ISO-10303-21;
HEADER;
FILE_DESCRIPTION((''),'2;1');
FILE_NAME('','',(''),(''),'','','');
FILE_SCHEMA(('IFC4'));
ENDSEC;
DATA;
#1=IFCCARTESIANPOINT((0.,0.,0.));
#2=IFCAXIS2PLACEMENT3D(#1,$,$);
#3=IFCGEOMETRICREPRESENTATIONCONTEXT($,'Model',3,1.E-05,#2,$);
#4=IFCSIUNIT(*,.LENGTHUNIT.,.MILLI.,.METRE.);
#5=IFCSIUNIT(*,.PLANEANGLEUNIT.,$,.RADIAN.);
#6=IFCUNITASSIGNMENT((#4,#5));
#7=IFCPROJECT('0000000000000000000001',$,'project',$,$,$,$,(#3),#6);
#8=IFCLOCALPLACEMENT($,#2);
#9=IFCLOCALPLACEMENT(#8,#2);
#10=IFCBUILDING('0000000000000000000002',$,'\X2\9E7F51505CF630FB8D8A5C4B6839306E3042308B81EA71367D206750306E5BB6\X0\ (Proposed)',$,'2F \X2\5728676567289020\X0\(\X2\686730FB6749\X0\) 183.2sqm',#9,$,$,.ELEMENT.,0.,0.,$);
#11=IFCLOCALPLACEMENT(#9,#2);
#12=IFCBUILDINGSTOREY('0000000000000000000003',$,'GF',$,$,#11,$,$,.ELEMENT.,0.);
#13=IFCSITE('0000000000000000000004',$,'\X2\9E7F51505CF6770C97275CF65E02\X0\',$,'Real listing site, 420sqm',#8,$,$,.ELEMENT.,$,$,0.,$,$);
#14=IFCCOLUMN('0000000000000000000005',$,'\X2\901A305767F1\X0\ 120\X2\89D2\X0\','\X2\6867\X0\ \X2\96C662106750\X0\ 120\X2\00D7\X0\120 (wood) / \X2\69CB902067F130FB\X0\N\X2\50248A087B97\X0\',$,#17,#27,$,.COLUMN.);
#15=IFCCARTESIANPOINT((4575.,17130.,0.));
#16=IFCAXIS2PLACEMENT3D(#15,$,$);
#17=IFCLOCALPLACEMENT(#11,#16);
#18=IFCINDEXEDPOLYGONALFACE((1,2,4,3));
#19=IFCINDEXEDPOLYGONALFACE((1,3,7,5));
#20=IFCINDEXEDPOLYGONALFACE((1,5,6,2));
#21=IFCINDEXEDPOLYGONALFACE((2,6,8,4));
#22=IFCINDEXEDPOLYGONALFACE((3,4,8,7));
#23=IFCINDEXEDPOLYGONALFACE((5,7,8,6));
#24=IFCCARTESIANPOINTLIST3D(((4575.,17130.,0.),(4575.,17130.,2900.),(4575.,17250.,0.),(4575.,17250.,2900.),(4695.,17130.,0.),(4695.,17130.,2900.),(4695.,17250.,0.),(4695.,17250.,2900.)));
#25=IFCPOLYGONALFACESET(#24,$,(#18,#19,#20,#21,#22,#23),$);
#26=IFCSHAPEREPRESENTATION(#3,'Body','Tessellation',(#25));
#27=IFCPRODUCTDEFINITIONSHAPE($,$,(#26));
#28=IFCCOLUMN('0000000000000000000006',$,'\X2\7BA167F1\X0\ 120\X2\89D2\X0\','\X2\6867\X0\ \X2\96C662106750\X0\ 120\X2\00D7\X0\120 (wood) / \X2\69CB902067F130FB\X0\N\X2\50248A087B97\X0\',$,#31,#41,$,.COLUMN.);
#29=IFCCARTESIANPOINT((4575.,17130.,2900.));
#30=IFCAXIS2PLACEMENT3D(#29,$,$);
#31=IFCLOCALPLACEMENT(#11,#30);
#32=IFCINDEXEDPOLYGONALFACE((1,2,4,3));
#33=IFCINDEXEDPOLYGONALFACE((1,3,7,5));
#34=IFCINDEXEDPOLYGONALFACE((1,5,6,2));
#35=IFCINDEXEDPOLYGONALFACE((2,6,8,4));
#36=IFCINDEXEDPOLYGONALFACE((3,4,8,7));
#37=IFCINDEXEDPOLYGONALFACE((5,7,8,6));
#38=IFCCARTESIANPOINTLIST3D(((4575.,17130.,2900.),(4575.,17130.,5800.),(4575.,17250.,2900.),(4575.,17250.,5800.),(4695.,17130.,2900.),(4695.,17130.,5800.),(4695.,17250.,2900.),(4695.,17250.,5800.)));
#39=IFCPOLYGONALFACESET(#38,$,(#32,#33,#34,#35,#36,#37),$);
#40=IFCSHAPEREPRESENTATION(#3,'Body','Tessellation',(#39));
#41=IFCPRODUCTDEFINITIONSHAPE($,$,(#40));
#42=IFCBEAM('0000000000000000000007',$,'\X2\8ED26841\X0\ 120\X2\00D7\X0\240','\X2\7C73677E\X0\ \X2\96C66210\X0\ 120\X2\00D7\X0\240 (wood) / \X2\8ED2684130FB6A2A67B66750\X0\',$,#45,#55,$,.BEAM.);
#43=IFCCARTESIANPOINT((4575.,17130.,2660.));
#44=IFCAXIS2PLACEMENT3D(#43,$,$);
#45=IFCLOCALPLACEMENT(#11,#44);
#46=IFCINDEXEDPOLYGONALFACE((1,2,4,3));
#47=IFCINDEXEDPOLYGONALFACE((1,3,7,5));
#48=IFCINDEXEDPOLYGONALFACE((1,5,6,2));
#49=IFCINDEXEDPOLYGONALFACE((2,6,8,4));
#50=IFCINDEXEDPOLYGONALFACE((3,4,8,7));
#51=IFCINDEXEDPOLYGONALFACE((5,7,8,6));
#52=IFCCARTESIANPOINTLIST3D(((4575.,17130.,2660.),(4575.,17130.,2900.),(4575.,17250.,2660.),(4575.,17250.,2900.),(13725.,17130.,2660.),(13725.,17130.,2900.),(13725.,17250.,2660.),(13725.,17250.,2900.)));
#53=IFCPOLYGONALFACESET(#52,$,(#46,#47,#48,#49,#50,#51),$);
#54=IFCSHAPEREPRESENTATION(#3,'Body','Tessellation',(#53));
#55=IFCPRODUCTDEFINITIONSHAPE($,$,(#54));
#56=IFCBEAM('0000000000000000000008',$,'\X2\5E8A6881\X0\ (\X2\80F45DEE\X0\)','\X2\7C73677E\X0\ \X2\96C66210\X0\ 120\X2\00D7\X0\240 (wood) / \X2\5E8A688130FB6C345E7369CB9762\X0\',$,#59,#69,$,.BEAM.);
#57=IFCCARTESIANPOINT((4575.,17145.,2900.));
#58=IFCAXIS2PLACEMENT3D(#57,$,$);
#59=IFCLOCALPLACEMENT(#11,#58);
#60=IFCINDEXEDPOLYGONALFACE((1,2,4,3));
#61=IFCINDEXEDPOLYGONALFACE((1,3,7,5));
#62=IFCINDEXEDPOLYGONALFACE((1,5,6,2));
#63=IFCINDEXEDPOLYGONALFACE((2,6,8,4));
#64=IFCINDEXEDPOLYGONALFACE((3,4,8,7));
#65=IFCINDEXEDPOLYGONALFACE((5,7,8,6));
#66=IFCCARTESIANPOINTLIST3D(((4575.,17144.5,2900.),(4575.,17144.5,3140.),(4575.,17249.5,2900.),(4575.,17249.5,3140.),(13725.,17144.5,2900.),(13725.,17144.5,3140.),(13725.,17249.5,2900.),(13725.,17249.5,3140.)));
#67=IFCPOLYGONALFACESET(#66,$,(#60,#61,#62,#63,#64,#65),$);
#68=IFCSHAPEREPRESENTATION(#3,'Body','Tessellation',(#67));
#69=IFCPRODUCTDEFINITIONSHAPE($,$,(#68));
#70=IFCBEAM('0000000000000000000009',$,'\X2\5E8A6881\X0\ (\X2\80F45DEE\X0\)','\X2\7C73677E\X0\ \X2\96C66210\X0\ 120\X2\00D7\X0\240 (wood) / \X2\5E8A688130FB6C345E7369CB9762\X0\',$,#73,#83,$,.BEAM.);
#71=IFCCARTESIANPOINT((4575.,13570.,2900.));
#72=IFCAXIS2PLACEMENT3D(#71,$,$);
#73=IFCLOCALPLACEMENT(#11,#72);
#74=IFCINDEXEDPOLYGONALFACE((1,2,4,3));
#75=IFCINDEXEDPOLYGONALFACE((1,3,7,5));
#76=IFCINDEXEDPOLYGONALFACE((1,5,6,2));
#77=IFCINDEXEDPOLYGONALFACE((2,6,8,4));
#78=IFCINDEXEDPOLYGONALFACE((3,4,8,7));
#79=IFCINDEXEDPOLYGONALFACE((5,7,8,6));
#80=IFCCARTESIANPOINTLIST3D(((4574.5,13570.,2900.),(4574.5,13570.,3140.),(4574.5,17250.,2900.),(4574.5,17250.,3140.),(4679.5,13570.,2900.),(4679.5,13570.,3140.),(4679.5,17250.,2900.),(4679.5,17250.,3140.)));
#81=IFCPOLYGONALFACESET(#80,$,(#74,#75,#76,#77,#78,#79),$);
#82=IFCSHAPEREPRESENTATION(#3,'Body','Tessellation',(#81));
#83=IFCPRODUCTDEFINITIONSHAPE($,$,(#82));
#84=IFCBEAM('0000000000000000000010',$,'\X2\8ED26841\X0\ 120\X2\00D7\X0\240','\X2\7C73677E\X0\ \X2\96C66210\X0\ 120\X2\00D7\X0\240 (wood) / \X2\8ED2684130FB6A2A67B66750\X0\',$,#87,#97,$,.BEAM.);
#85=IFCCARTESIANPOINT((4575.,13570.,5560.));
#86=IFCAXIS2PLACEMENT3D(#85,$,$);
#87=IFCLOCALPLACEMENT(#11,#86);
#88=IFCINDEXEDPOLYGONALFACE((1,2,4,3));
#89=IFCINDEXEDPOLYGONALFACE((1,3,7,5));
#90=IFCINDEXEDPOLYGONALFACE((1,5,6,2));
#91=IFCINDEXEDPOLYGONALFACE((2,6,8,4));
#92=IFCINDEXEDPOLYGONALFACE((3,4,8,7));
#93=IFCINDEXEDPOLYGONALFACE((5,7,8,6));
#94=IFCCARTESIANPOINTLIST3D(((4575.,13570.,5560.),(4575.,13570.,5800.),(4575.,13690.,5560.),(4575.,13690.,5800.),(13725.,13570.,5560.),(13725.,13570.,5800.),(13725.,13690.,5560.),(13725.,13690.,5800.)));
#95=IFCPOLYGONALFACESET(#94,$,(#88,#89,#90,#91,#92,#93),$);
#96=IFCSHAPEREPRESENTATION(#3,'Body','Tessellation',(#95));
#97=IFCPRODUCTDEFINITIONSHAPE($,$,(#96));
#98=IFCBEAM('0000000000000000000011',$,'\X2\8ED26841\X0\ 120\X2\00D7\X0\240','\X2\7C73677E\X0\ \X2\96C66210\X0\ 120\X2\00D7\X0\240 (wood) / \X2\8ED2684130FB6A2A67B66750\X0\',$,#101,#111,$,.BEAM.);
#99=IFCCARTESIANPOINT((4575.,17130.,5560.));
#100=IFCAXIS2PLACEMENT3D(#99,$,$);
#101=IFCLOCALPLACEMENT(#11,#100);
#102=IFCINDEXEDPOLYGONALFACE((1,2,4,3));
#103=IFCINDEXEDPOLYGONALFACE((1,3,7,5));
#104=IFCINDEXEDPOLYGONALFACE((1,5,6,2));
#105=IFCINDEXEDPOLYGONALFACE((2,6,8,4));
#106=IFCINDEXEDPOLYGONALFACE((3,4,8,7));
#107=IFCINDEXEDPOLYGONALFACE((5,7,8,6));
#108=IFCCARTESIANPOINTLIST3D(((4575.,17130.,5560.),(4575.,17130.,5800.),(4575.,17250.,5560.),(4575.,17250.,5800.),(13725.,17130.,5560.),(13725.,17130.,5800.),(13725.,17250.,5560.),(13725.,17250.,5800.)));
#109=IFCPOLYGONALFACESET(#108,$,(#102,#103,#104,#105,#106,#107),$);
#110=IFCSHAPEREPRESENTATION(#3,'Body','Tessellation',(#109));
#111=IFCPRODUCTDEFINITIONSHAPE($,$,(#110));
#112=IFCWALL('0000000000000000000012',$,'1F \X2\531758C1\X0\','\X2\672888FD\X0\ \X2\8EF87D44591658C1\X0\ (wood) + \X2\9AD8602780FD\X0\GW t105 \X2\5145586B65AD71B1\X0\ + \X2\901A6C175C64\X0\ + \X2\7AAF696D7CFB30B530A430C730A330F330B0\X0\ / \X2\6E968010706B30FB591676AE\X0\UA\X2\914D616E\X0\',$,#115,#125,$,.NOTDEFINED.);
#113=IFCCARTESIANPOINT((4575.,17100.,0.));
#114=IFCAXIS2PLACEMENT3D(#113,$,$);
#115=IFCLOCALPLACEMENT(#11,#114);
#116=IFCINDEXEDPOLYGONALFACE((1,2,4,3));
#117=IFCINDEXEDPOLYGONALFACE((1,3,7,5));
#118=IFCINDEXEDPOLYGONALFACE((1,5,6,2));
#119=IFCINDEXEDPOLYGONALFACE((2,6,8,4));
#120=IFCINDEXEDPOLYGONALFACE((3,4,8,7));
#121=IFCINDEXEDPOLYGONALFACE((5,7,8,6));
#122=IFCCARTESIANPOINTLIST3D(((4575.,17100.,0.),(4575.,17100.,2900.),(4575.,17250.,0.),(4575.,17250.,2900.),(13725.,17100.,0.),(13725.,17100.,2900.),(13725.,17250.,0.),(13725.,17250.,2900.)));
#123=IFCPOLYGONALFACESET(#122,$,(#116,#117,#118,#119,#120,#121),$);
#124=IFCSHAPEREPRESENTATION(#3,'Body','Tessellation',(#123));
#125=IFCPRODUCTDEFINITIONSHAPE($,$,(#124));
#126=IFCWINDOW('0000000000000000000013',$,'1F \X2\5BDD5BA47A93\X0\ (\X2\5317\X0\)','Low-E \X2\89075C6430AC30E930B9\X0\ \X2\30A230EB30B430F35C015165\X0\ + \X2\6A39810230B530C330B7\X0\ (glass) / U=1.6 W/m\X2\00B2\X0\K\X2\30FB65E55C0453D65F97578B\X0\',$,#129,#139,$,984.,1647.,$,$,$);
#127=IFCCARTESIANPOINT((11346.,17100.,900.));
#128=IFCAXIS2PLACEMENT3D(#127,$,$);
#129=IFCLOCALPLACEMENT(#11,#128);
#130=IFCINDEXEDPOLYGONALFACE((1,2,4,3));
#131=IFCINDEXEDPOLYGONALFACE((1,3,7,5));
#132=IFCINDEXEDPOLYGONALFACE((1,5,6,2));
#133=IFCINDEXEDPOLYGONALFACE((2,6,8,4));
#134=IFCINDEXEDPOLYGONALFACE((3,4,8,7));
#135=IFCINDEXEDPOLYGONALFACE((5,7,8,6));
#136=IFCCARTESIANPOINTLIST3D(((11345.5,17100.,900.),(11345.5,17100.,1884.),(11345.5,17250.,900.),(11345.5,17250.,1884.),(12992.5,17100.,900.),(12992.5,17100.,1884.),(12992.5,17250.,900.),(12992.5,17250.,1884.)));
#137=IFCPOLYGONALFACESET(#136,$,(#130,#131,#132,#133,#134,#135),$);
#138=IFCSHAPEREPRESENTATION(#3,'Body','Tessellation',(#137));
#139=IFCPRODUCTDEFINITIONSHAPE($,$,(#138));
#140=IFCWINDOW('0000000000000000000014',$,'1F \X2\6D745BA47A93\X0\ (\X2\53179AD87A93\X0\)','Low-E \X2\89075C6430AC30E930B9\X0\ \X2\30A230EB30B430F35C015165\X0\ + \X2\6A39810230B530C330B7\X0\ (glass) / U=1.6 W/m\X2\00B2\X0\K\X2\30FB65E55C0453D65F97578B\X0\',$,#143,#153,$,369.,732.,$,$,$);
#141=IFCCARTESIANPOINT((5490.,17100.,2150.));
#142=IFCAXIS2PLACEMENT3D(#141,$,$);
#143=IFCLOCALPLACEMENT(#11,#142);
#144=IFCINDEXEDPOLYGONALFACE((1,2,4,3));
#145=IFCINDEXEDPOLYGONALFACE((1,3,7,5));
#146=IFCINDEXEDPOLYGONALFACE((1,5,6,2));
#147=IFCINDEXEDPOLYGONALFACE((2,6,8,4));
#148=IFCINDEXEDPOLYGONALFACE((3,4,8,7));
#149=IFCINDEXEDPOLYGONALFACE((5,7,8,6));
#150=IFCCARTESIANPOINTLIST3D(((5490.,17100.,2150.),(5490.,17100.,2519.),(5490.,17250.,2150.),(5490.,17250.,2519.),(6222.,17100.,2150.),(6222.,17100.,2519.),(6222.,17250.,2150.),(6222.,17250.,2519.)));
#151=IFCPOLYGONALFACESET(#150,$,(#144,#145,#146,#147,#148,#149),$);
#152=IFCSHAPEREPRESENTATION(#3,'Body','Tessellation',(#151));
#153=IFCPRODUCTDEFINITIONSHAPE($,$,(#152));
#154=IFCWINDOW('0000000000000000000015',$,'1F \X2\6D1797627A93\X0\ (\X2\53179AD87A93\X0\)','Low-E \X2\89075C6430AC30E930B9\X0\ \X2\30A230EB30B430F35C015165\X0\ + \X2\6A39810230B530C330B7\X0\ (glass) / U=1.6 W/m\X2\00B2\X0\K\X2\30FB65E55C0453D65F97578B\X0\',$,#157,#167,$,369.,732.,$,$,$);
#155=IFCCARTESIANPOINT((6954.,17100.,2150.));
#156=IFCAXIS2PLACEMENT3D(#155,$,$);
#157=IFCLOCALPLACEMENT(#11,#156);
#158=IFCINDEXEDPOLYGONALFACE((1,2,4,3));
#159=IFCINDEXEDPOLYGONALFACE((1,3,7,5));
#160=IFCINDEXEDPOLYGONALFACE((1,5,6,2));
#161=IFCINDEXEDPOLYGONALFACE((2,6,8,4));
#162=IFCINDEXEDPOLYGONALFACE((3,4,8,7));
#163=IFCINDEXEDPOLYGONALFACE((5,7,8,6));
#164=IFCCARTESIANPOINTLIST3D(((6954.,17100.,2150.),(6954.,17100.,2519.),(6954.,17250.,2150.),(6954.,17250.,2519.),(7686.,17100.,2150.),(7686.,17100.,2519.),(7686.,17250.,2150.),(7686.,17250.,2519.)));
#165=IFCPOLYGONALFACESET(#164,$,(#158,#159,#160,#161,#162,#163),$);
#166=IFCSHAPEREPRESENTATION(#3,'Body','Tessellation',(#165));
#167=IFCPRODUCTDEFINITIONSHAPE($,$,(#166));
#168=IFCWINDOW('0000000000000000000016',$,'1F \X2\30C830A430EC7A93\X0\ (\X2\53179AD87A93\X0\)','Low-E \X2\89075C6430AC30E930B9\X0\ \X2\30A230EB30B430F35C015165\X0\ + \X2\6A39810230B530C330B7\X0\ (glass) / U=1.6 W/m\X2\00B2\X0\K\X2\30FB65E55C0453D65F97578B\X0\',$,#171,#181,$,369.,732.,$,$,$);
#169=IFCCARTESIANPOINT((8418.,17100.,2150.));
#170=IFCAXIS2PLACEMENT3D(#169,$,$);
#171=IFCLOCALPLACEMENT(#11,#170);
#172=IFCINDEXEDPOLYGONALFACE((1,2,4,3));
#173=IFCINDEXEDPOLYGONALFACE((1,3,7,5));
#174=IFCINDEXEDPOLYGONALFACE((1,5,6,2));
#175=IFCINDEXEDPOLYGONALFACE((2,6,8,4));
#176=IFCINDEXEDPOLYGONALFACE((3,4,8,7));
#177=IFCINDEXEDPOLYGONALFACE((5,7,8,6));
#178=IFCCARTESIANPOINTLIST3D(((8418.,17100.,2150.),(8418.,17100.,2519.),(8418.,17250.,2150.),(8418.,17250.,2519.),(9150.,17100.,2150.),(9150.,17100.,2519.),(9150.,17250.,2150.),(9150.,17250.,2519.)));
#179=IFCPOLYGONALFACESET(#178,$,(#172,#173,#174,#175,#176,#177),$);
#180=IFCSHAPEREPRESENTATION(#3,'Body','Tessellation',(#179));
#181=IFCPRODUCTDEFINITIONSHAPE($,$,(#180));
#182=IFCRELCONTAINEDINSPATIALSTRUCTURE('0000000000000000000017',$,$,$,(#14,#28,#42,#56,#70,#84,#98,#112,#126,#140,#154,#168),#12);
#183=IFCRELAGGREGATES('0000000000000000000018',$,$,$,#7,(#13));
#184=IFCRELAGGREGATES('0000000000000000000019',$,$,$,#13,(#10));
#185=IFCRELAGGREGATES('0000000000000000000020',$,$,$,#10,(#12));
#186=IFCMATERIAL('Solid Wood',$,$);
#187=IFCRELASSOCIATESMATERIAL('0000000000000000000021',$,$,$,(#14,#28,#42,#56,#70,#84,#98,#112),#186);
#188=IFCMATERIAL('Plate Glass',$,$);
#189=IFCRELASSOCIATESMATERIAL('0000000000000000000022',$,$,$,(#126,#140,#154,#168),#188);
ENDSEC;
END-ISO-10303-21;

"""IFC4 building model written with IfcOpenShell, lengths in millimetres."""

from ifc_helpers import new_model, si_unit, frame, frame_2d, origin, place, context, project, spatial, rectangle, extrude, material, element, fill, save


model = new_model("IFC4")

# Units and contexts
model_context = context("Model", 3, precision=1e-05, world=origin())
ifc_project = project(units=[si_unit("LENGTHUNIT", "METRE", prefix="MILLI"), si_unit("PLANEANGLEUNIT", "RADIAN")], contexts=[model_context])

# Site, building, storey
site_placement = place(None, origin())
site = spatial("IfcSite", under=ifc_project, at=site_placement, Name="鹿児島県霧島市", ObjectType="Real listing site, 420sqm", CompositionType="ELEMENT", RefElevation=0.0)
building_placement = place(site_placement, origin())
building = spatial("IfcBuilding", under=site, at=building_placement, Name="鹿児島・越屋根のある自然素材の家 (Proposed)", ObjectType="2F 在来木造(桧・杉) 183.2sqm", CompositionType="ELEMENT", ElevationOfRefHeight=0.0, ElevationOfTerrain=0.0)
storey_placement = place(building_placement, origin())
storey = spatial("IfcBuildingStorey", under=building, at=storey_placement, Name="GF", CompositionType="ELEMENT", Elevation=0.0)

# Columns
ifc_material_1 = material(Name="Solid Wood")
column_1_placement = place(storey_placement, frame((4575.0, 17130.0, 0.0)))
element("IfcColumn", 1, at=column_1_placement, inside=storey, material=ifc_material_1, Name="通し柱 120角", Description="桧 集成材 120×120 (wood) / 構造柱・N値計算", PredefinedType="COLUMN", context=model_context, shape_type="SweptSolid", body=[
    extrude(rectangle(XDim=120.0, YDim=120.0, at=frame_2d((60.0, 60.0))), frame((4575.0, 17130.0, 0.0)), (0.0, 0.0, 1.0), 2900.0),
])
column_2_placement = place(storey_placement, frame((4575.0, 17130.0, 2900.0)))
element("IfcColumn", 2, at=column_2_placement, inside=storey, material=ifc_material_1, Name="管柱 120角", Description="桧 集成材 120×120 (wood) / 構造柱・N値計算", PredefinedType="COLUMN", context=model_context, shape_type="SweptSolid", body=[
    extrude(rectangle(XDim=120.0, YDim=120.0, at=frame_2d((60.0, 60.0))), frame((4575.0, 17130.0, 2900.0)), (0.0, 0.0, 1.0), 2900.0),
])

# Beams
beam_1_placement = place(storey_placement, frame((4575.0, 17130.0, 2660.0)))
element("IfcBeam", 3, at=beam_1_placement, inside=storey, material=ifc_material_1, Name="軒桁 120×240", Description="米松 集成 120×240 (wood) / 軒桁・横架材", PredefinedType="BEAM", context=model_context, shape_type="SweptSolid", body=[
    extrude(rectangle(XDim=9150.0, YDim=120.0, at=frame_2d((4575.0, 60.0))), frame((4575.0, 17130.0, 2660.0)), (0.0, 0.0, 1.0), 240.0),
])
beam_2_placement = place(storey_placement, frame((4575.0, 17145.0, 2900.0)))
element("IfcBeam", 4, at=beam_2_placement, inside=storey, material=ifc_material_1, Name="床梁 (胴差)", Description="米松 集成 120×240 (wood) / 床梁・水平構面", PredefinedType="BEAM", context=model_context, shape_type="SweptSolid", body=[
    extrude(rectangle(XDim=9150.0, YDim=105.0, at=frame_2d((4575.0, 52.0))), frame((4575.0, 17145.0, 2900.0)), (0.0, 0.0, 1.0), 240.0),
])
beam_3_placement = place(storey_placement, frame((4575.0, 13570.0, 2900.0)))
element("IfcBeam", 5, at=beam_3_placement, inside=storey, material=ifc_material_1, Name="床梁 (胴差)", Description="米松 集成 120×240 (wood) / 床梁・水平構面", PredefinedType="BEAM", context=model_context, shape_type="SweptSolid", body=[
    extrude(rectangle(XDim=105.0, YDim=3680.0, at=frame_2d((52.0, 1840.0))), frame((4575.0, 13570.0, 2900.0)), (0.0, 0.0, 1.0), 240.0),
])
beam_4_placement = place(storey_placement, frame((4575.0, 13570.0, 5560.0)))
element("IfcBeam", 6, at=beam_4_placement, inside=storey, material=ifc_material_1, Name="軒桁 120×240", Description="米松 集成 120×240 (wood) / 軒桁・横架材", PredefinedType="BEAM", context=model_context, shape_type="SweptSolid", body=[
    extrude(rectangle(XDim=9150.0, YDim=120.0, at=frame_2d((4575.0, 60.0))), frame((4575.0, 13570.0, 5560.0)), (0.0, 0.0, 1.0), 240.0),
])
beam_5_placement = place(storey_placement, frame((4575.0, 17130.0, 5560.0)))
element("IfcBeam", 7, at=beam_5_placement, inside=storey, material=ifc_material_1, Name="軒桁 120×240", Description="米松 集成 120×240 (wood) / 軒桁・横架材", PredefinedType="BEAM", context=model_context, shape_type="SweptSolid", body=[
    extrude(rectangle(XDim=9150.0, YDim=120.0, at=frame_2d((4575.0, 60.0))), frame((4575.0, 17130.0, 5560.0)), (0.0, 0.0, 1.0), 240.0),
])

# Wall, openings, windows
wall_1_placement = place(storey_placement, frame((4575.0, 17100.0, 0.0)))
wall_1 = element("IfcWall", 8, at=wall_1_placement, inside=storey, material=ifc_material_1, Name="1F 北壁", Description="木製 軸組外壁 (wood) + 高性能GW t105 充填断熱 + 通気層 + 窯業系サイディング / 準耐火・外皮UA配慮", PredefinedType="NOTDEFINED", context=model_context, shape_type="SweptSolid", body=[
    extrude(rectangle(XDim=9150.0, YDim=150.0, at=frame_2d((4575.0, 75.0))), frame((4575.0, 17100.0, 0.0)), (0.0, 0.0, 1.0), 2900.0),
])
opening_1_placement = place(storey_placement, frame((11346.0, 17100.0, 900.0)))
opening_1 = element("IfcOpeningElement", 9, at=opening_1_placement, cuts=wall_1, PredefinedType="NOTDEFINED", context=model_context, shape_type="SweptSolid", body=[
    extrude(rectangle(XDim=1647.0, YDim=150.0, at=frame_2d((823.0, 75.0))), frame((11346.0, 17100.0, 900.0)), (0.0, 0.0, 1.0), 984.0),
])
opening_2_placement = place(storey_placement, frame((5490.0, 17100.0, 2150.0)))
opening_2 = element("IfcOpeningElement", 10, at=opening_2_placement, cuts=wall_1, PredefinedType="NOTDEFINED", context=model_context, shape_type="SweptSolid", body=[
    extrude(rectangle(XDim=732.0, YDim=150.0, at=frame_2d((366.0, 75.0))), frame((5490.0, 17100.0, 2150.0)), (0.0, 0.0, 1.0), 369.0),
])
opening_3_placement = place(storey_placement, frame((6954.0, 17100.0, 2150.0)))
opening_3 = element("IfcOpeningElement", 11, at=opening_3_placement, cuts=wall_1, PredefinedType="NOTDEFINED", context=model_context, shape_type="SweptSolid", body=[
    extrude(rectangle(XDim=732.0, YDim=150.0, at=frame_2d((366.0, 75.0))), frame((6954.0, 17100.0, 2150.0)), (0.0, 0.0, 1.0), 369.0),
])
opening_4_placement = place(storey_placement, frame((8418.0, 17100.0, 2150.0)))
opening_4 = element("IfcOpeningElement", 12, at=opening_4_placement, cuts=wall_1, PredefinedType="NOTDEFINED", context=model_context, shape_type="SweptSolid", body=[
    extrude(rectangle(XDim=732.0, YDim=150.0, at=frame_2d((366.0, 75.0))), frame((8418.0, 17100.0, 2150.0)), (0.0, 0.0, 1.0), 369.0),
])
ifc_material_2 = material(Name="Plate Glass")
window_1_placement = place(storey_placement, frame((11346.0, 17100.0, 900.0)))
window_1 = element("IfcWindow", 13, at=window_1_placement, inside=storey, material=ifc_material_2, Name="1F 寝室窓 (北)", Description="Low-E 複層ガラス アルゴン封入 + 樹脂サッシ (glass) / U=1.6 W/m²K・日射取得型", OverallHeight=984.0, OverallWidth=1647.0, context=model_context, shape_type="SweptSolid", body=[
    extrude(rectangle(XDim=1647.0, YDim=150.0, at=frame_2d((823.0, 75.0))), frame((11346.0, 17100.0, 900.0)), (0.0, 0.0, 1.0), 984.0),
])
fill(opening_1, window_1)
window_2_placement = place(storey_placement, frame((5490.0, 17100.0, 2150.0)))
window_2 = element("IfcWindow", 14, at=window_2_placement, inside=storey, material=ifc_material_2, Name="1F 浴室窓 (北高窓)", Description="Low-E 複層ガラス アルゴン封入 + 樹脂サッシ (glass) / U=1.6 W/m²K・日射取得型", OverallHeight=369.0, OverallWidth=732.0, context=model_context, shape_type="SweptSolid", body=[
    extrude(rectangle(XDim=732.0, YDim=150.0, at=frame_2d((366.0, 75.0))), frame((5490.0, 17100.0, 2150.0)), (0.0, 0.0, 1.0), 369.0),
])
fill(opening_2, window_2)
window_3_placement = place(storey_placement, frame((6954.0, 17100.0, 2150.0)))
window_3 = element("IfcWindow", 15, at=window_3_placement, inside=storey, material=ifc_material_2, Name="1F 洗面窓 (北高窓)", Description="Low-E 複層ガラス アルゴン封入 + 樹脂サッシ (glass) / U=1.6 W/m²K・日射取得型", OverallHeight=369.0, OverallWidth=732.0, context=model_context, shape_type="SweptSolid", body=[
    extrude(rectangle(XDim=732.0, YDim=150.0, at=frame_2d((366.0, 75.0))), frame((6954.0, 17100.0, 2150.0)), (0.0, 0.0, 1.0), 369.0),
])
fill(opening_3, window_3)
window_4_placement = place(storey_placement, frame((8418.0, 17100.0, 2150.0)))
window_4 = element("IfcWindow", 16, at=window_4_placement, inside=storey, material=ifc_material_2, Name="1F トイレ窓 (北高窓)", Description="Low-E 複層ガラス アルゴン封入 + 樹脂サッシ (glass) / U=1.6 W/m²K・日射取得型", OverallHeight=369.0, OverallWidth=732.0, context=model_context, shape_type="SweptSolid", body=[
    extrude(rectangle(XDim=732.0, YDim=150.0, at=frame_2d((366.0, 75.0))), frame((8418.0, 17100.0, 2150.0)), (0.0, 0.0, 1.0), 369.0),
])
fill(opening_4, window_4)

save(model, "model.ifc")
